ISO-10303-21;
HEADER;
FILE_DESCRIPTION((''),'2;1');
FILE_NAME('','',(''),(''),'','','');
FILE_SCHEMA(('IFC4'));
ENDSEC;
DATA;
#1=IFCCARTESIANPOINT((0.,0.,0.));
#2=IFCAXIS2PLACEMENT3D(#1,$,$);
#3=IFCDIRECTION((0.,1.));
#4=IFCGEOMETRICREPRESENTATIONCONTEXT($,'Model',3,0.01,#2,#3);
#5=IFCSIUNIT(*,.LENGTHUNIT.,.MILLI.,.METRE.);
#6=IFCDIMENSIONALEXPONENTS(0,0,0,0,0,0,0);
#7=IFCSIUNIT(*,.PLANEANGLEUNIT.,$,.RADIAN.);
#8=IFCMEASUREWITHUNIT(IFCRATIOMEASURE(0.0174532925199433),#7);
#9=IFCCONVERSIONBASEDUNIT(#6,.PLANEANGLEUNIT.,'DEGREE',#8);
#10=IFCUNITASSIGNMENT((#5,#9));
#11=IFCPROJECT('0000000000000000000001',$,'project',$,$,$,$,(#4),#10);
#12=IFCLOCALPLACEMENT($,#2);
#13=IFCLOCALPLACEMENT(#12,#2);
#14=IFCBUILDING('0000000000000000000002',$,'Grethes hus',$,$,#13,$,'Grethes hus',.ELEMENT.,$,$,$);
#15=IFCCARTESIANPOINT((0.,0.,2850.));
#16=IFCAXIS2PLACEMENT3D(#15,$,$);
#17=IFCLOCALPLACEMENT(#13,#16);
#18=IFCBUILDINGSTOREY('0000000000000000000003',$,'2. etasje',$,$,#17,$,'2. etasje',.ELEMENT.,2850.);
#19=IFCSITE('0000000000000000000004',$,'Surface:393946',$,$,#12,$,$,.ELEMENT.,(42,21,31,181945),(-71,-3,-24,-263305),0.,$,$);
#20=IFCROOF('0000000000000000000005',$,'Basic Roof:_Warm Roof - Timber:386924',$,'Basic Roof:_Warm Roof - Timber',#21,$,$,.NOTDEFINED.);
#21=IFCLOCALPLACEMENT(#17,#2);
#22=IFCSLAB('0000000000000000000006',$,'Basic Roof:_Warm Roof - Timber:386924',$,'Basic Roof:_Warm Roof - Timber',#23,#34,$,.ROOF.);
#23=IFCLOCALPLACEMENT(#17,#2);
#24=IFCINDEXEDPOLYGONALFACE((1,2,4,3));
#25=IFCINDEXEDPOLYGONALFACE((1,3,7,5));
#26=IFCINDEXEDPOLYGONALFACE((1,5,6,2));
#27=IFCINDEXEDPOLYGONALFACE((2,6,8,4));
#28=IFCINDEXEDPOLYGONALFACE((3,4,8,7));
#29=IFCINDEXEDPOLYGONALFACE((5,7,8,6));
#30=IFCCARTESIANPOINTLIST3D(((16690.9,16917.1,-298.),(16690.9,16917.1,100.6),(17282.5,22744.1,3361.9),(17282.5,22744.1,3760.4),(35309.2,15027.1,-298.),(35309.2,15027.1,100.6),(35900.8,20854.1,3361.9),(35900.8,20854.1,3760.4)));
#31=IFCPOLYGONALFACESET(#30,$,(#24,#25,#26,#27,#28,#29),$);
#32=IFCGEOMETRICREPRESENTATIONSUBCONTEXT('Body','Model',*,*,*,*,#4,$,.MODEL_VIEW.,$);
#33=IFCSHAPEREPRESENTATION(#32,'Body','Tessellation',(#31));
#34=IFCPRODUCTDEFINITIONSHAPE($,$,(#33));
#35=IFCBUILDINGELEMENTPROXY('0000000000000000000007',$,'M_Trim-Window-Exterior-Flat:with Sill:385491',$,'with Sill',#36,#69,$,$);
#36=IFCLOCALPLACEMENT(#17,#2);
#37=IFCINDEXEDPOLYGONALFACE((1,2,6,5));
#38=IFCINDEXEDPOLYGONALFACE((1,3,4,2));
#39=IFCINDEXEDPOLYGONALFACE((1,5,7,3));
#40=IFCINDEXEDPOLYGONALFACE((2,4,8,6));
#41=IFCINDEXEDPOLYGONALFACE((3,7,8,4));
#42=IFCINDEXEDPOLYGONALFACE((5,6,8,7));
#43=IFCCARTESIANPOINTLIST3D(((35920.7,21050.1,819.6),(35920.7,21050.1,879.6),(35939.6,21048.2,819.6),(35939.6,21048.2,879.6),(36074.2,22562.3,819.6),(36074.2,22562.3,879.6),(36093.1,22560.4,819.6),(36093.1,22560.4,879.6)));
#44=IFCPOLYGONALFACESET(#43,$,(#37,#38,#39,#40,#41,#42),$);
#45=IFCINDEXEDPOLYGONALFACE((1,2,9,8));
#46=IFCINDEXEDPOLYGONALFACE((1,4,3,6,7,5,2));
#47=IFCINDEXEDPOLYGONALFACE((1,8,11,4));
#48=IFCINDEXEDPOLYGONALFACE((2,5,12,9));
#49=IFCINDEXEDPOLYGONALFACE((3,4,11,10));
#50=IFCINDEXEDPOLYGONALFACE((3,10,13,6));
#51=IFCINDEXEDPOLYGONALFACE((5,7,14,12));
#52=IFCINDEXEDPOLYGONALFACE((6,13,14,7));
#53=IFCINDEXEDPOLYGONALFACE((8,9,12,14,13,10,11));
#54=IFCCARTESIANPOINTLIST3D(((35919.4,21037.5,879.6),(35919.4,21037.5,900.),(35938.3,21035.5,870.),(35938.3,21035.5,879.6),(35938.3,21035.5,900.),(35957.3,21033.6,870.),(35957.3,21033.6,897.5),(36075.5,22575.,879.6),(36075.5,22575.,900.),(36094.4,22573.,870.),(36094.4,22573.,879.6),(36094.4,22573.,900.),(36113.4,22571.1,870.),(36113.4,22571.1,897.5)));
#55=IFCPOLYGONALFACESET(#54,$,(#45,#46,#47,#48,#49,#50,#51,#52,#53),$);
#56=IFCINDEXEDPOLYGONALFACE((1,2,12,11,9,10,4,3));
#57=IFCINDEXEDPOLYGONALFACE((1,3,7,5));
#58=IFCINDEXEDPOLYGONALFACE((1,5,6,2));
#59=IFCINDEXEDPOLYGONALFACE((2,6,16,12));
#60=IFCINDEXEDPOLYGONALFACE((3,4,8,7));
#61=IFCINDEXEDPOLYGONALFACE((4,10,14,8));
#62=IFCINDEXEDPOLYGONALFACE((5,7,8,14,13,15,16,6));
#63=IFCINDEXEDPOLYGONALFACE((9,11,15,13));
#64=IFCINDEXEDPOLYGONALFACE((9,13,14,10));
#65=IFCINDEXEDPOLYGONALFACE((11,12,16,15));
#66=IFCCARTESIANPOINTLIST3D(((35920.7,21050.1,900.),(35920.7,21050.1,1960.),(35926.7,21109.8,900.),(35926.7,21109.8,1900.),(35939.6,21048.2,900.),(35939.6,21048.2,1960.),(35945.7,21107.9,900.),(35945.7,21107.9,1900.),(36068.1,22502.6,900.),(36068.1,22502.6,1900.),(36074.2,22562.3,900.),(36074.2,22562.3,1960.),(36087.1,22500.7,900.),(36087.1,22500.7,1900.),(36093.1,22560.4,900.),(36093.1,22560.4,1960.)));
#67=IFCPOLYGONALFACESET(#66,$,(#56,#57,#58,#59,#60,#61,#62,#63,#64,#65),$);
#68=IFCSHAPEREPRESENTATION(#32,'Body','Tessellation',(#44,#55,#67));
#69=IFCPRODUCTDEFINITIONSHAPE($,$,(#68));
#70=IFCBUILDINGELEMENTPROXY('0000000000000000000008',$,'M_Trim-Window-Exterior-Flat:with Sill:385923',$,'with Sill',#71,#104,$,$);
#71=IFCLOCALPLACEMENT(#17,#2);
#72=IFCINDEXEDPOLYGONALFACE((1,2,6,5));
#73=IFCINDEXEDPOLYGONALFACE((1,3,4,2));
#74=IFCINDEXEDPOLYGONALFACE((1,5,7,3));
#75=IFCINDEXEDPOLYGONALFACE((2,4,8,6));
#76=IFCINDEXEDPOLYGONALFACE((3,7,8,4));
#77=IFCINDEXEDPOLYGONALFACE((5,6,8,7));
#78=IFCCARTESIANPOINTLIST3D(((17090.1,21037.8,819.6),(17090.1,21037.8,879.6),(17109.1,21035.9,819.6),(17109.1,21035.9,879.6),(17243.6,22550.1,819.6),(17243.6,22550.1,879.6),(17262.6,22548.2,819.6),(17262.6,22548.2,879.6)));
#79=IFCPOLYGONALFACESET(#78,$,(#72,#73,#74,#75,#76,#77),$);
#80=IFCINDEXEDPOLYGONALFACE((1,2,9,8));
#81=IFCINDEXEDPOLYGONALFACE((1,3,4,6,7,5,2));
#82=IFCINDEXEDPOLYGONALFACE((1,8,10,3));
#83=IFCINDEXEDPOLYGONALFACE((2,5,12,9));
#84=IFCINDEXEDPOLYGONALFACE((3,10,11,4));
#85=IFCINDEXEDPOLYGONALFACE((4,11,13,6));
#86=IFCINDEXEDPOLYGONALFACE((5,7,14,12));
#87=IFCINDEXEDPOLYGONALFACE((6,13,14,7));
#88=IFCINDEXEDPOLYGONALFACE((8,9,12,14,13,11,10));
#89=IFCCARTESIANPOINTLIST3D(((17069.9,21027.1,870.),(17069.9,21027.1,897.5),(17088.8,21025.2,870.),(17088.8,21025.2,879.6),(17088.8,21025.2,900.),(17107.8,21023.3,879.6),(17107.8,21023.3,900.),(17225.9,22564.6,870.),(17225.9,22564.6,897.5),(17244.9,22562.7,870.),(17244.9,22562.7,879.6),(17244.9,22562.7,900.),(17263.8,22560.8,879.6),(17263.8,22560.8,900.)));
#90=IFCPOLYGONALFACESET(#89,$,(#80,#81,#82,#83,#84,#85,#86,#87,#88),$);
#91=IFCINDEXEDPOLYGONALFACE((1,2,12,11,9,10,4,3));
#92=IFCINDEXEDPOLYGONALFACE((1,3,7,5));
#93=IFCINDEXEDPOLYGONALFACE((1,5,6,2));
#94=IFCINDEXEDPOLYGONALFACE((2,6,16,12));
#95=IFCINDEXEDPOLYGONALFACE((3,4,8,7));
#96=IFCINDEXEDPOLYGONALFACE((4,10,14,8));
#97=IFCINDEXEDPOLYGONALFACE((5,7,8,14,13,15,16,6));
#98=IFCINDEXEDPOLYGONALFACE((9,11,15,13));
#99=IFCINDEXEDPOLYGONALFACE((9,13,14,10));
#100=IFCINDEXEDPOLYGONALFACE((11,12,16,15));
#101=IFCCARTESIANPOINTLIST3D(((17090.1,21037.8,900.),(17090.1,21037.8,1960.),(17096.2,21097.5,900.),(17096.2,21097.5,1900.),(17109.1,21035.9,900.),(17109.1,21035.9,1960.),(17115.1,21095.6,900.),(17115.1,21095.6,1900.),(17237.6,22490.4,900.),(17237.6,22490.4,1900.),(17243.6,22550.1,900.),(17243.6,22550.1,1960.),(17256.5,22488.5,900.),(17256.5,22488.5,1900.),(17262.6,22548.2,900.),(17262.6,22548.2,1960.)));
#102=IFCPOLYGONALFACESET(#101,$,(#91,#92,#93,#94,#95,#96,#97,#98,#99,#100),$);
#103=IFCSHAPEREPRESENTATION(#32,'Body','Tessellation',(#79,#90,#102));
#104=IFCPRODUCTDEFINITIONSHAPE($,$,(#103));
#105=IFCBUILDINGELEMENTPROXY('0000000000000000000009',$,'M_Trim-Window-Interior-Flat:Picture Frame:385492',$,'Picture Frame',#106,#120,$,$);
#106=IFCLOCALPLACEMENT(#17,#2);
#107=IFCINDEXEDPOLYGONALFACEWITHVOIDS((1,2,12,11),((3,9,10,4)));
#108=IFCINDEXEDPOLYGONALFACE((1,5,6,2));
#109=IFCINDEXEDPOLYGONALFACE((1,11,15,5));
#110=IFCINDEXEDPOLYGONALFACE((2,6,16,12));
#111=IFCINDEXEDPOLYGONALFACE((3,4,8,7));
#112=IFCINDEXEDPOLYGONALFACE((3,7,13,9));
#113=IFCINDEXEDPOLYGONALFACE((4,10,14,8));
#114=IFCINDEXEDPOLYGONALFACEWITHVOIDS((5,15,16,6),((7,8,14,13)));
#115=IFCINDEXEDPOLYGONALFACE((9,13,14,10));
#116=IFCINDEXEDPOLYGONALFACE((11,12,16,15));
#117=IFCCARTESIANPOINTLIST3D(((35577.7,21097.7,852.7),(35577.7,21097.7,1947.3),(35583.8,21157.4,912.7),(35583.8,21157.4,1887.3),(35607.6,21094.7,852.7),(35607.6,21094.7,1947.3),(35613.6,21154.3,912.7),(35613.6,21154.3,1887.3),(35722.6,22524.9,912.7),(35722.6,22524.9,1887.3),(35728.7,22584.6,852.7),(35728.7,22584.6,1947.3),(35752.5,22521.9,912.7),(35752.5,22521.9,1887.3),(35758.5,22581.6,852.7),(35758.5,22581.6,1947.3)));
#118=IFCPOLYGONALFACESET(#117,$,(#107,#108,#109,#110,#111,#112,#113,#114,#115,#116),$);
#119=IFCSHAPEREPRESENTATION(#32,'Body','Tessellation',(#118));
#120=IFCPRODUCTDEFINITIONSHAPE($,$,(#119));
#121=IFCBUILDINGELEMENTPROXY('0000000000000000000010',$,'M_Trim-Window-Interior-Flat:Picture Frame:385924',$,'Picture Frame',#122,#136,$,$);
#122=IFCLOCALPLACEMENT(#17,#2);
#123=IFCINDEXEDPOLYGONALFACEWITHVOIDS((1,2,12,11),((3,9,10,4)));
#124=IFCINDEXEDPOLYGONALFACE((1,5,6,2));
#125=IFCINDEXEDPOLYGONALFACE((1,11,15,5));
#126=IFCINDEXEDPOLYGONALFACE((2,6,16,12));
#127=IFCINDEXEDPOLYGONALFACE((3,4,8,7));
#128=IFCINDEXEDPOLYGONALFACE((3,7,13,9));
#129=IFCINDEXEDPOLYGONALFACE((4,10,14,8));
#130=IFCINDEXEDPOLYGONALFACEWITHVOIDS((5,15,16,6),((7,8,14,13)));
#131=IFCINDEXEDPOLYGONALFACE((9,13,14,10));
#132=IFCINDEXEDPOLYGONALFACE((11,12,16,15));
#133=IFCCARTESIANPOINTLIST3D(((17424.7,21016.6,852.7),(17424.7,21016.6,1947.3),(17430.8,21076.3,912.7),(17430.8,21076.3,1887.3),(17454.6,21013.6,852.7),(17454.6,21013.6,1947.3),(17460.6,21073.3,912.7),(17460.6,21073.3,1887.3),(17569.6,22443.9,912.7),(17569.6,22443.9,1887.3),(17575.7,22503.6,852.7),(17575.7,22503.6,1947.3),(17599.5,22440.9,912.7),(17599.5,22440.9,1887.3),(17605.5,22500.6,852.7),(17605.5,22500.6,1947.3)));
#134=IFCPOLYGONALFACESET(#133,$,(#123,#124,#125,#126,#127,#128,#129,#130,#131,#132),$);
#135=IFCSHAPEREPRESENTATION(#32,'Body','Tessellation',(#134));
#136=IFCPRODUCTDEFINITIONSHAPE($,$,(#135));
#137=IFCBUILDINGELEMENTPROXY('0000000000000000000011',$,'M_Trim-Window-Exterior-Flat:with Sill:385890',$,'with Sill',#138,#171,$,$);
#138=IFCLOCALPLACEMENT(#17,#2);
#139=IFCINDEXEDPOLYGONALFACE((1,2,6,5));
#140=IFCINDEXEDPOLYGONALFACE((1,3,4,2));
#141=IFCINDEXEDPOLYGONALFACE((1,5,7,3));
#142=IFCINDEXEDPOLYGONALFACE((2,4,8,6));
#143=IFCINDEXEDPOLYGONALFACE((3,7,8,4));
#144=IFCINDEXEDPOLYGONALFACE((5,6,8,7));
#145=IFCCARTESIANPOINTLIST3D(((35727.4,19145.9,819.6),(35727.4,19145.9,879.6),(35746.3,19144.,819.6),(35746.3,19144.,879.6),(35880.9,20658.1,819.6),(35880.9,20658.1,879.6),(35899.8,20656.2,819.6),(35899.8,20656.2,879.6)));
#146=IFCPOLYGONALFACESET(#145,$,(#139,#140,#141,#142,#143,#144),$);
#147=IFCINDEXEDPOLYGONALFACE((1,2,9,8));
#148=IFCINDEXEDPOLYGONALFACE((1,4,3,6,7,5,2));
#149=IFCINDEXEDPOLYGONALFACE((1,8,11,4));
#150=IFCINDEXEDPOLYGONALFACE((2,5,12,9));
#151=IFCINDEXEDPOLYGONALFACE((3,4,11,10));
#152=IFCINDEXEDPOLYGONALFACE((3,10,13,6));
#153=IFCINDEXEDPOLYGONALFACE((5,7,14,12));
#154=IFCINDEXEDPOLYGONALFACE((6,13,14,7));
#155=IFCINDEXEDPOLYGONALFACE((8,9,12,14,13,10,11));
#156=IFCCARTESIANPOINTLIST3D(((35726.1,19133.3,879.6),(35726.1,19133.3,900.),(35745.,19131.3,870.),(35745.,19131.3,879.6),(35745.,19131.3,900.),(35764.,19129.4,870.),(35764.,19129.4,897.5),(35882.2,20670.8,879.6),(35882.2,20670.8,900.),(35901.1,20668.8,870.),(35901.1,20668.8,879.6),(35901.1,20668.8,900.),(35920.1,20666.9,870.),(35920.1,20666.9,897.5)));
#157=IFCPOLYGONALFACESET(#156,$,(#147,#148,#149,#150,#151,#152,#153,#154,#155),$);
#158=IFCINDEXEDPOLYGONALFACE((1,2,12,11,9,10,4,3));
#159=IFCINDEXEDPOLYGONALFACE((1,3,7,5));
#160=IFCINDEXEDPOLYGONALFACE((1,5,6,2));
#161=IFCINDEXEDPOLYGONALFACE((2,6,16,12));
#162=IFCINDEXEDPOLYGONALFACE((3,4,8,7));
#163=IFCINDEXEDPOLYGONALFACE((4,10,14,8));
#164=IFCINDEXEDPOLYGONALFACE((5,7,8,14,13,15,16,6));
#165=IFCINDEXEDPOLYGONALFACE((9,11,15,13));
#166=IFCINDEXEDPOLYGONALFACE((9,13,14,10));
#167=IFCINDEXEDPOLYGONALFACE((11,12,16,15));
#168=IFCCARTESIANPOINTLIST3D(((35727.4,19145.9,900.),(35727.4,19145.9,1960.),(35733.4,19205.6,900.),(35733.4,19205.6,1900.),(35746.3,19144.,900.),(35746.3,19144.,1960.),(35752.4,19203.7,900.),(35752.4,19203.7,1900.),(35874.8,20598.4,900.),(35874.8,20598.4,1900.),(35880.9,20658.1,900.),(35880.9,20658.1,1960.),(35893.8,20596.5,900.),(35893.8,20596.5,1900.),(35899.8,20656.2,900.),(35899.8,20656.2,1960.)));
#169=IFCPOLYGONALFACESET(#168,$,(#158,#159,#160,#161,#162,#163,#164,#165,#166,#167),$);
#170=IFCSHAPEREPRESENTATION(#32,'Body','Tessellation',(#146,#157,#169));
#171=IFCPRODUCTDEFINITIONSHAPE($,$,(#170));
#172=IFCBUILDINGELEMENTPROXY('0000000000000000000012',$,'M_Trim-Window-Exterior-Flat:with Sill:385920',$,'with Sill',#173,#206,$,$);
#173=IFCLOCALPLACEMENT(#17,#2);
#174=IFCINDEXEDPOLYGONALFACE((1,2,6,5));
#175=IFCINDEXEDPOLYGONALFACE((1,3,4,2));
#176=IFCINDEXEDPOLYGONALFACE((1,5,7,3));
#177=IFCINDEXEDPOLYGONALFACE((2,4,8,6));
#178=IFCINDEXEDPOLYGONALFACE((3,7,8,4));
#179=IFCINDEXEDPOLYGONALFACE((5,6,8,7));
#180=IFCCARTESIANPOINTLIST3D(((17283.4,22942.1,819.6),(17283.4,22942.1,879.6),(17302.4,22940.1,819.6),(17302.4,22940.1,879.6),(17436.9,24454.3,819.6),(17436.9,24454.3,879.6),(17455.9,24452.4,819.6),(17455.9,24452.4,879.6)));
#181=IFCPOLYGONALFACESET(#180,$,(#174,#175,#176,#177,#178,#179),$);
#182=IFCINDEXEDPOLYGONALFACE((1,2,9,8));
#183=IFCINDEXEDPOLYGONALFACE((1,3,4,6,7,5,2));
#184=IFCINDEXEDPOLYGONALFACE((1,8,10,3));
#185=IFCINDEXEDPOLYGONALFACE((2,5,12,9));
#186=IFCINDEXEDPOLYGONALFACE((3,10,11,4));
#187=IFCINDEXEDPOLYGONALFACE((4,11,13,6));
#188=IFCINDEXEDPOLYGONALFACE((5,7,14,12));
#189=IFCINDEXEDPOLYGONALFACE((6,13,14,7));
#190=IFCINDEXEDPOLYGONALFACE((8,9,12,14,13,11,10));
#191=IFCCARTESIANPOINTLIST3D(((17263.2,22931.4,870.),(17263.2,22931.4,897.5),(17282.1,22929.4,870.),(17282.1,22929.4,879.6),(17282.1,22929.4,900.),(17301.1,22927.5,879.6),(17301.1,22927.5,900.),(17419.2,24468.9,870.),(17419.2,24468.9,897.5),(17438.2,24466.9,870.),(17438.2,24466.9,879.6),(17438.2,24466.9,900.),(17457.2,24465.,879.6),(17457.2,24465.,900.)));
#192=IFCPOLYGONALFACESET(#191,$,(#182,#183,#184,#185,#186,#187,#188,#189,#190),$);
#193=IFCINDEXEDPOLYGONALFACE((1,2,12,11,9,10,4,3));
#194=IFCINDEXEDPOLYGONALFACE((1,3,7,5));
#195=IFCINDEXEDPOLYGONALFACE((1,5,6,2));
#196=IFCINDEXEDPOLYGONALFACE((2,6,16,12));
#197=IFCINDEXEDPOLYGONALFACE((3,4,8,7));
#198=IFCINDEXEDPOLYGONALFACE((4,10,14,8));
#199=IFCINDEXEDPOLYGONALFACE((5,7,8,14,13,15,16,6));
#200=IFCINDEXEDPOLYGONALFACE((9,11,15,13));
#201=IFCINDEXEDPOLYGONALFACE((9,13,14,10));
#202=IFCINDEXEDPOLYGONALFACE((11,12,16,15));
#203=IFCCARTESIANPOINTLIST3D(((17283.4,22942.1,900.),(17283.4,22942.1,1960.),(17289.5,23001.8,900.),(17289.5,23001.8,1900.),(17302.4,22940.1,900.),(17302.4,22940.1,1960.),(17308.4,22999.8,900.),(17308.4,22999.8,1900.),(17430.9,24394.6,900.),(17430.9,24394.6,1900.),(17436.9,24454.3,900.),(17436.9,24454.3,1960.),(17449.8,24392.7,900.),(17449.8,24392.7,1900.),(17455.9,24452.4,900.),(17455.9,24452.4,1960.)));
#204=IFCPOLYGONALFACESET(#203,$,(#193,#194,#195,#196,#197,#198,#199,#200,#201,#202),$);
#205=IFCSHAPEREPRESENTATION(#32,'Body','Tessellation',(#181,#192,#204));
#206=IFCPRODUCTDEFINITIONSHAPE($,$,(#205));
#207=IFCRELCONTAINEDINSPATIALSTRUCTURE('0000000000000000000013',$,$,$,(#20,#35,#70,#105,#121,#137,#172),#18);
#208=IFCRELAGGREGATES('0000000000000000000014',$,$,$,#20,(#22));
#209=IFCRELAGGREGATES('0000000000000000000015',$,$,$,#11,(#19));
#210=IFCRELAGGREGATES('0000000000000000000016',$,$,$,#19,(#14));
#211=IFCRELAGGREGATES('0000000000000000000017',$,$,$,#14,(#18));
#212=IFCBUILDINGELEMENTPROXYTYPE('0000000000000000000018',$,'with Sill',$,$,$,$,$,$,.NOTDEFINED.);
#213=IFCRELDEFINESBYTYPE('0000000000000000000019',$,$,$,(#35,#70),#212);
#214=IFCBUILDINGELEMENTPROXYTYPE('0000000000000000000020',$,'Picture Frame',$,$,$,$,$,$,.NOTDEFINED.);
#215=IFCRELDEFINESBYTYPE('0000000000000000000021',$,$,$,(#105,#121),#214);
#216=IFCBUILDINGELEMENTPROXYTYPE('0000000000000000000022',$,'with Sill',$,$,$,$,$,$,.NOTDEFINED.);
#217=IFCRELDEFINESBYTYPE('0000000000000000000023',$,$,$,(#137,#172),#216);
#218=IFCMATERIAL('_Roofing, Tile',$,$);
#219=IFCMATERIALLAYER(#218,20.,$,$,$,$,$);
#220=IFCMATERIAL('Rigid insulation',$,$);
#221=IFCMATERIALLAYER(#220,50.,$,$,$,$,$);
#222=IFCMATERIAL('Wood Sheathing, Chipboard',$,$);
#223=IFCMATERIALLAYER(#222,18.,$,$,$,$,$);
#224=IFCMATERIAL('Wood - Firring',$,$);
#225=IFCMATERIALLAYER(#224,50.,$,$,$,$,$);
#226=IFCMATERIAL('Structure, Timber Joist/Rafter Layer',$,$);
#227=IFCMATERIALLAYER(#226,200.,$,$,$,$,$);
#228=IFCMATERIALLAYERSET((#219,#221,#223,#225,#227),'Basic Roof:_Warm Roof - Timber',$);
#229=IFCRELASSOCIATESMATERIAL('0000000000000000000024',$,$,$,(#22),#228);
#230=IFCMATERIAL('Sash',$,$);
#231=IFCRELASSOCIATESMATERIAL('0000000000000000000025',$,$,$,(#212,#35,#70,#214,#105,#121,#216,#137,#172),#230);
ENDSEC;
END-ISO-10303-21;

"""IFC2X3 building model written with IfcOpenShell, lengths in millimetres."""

from ifc_helpers import new_model, entity, si_unit, converted_unit, direction, frame, frame_2d, origin, place, context, subcontext, project, spatial, polyline, rectangle, outline, extrude, source, transform, mapped, material, layer, layer_set, type_object, type_shapes, element, aggregate, save


model = new_model("IFC2X3")

# Units and contexts
model_context = context("Model", 3, precision=0.01, world=origin(), true_north=direction((0.0, 1.0)))
body_context = subcontext(model_context, "Body", "Model", "MODEL_VIEW")
ifc_project = project(units=[si_unit("LENGTHUNIT", "METRE", prefix="MILLI"), converted_unit("PLANEANGLEUNIT", "DEGREE", entity("IfcRatioMeasure", 0.0174532925199433), si_unit("PLANEANGLEUNIT", "RADIAN"), dimensions=[0, 0, 0, 0, 0, 0, 0])], contexts=[model_context])

# Site, building, storey
site_placement = place(None, origin())
site = spatial("IfcSite", under=ifc_project, at=site_placement, Name="Surface:393946", CompositionType="ELEMENT", RefLatitude=(42, 21, 31, 181945), RefLongitude=(-71, -3, -24, -263305), RefElevation=0.0)
building_placement = place(site_placement, origin())
building = spatial("IfcBuilding", under=site, at=building_placement, Name="Grethes hus", LongName="Grethes hus", CompositionType="ELEMENT")
storey_placement = place(building_placement, frame((0.0, 0.0, 2850.0)))
storey = spatial("IfcBuildingStorey", under=building, at=storey_placement, Name="2. etasje", LongName="2. etasje", CompositionType="ELEMENT", Elevation=2850.0)

# Shared definitions
ifc_material_1 = material(Name="Wood Sheathing, Chipboard")
ifc_material_2 = material(Name="Structure, Timber Joist/Rafter Layer")

# Roof, slab
roof_placement = place(storey_placement, frame((16690.9, 15027.1, -298.0)))
roof = element("IfcRoof", 1, at=roof_placement, inside=storey, Name="Basic Roof:_Warm Roof - Timber:386924", ObjectType="Basic Roof:_Warm Roof - Timber", ShapeType="NOTDEFINED")
ifc_material_3 = material(Name="_Roofing, Tile")
ifc_layer_1 = layer(ifc_material_3, 20.0)
ifc_material_4 = material(Name="Rigid insulation")
ifc_layer_2 = layer(ifc_material_4, 50.0)
ifc_layer_3 = layer(ifc_material_1, 18.0)
ifc_material_5 = material(Name="Wood - Firring")
ifc_layer_4 = layer(ifc_material_5, 50.0)
ifc_layer_5 = layer(ifc_material_2, 200.0)
ifc_layer_set_1 = layer_set([ifc_layer_1, ifc_layer_2, ifc_layer_3, ifc_layer_4, ifc_layer_5], Name="Basic Roof:_Warm Roof - Timber")
slab_1_placement = place(roof_placement, origin())
slab_1 = element("IfcSlab", 2, at=slab_1_placement, material=ifc_layer_set_1, Name="Basic Roof:_Warm Roof - Timber:386924", ObjectType="Basic Roof:_Warm Roof - Timber", PredefinedType="ROOF", context=body_context, shape_type="SweptSolid", body=[
    extrude(rectangle(XDim=6906.4, YDim=18714.0, at=frame_2d((0.0, 0.0), x_axis=(0.085772, 0.996315))), frame((9604.9, 3858.5, 1829.9), z_axis=(-0.05352, -0.52721, 0.848048), x_axis=(0.998567, -0.028257, 0.045452)), (0.045452, 0.527966, 0.848048), 398.6),
])
aggregate(roof, [slab_1])

# Building element proxies
ifc_material_6 = material(Name="Sash")
building_element_proxy_type_1 = type_object("IfcBuildingElementProxyType", Name="with Sill", PredefinedType="NOTDEFINED", material=ifc_material_6)
shared_shape_1 = source(origin(), body_context, "Body", "SweptSolid", [
    extrude(rectangle(XDim=1520.0, YDim=60.0, at=frame_2d((0.0, 0.0), x_axis=(1.0, 0.0))), frame((0.0, -1050.4, 0.0), z_axis=(0.0, 0.0, 1.0), x_axis=(-1.0, 0.0, 0.0)), (0.0, 0.0, 1.0), 19.1),
    extrude(outline(polyline([(-19.0, -15.2), (0.0, -15.2), (0.0, -5.7), (19.0, -5.7), (19.0, 14.8), (0.0, 14.8), (-19.0, 12.3), (-19.0, -15.2)])), frame((-772.7, -1014.8, 19.0), z_axis=(1.0, 0.0, 0.0), x_axis=(0.0, 0.0, -1.0)), (0.0, 0.0, 1.0), 1545.4),
    extrude(outline(polyline([(-545.0, -760.0), (515.0, -760.0), (515.0, -700.0), (-485.0, -700.0), (-485.0, 700.0), (515.0, 700.0), (515.0, 760.0), (-545.0, 760.0), (-545.0, -760.0)])), frame((0.0, -485.0, 0.0), z_axis=(0.0, 0.0, 1.0), x_axis=(0.0, -1.0, 0.0)), (0.0, 0.0, 1.0), 19.1),
])
type_shapes(building_element_proxy_type_1, [shared_shape_1])
for number, where, z_axis, x_axis, name in (
    (3, (35997.4, 21806.2, 1900.0), (0.994887, -0.100996, 0.0), (0.100996, 0.994887, 0.0), "M_Trim-Window-Exterior-Flat:with Sill:385491"),
    (4, (17185.8, 21792.0, 1900.0), (-0.994887, 0.100996, 0.0), (-0.100996, -0.994887, 0.0), "M_Trim-Window-Exterior-Flat:with Sill:385923"),
):
    element("IfcBuildingElementProxy", number, at=place(storey_placement, frame(where, z_axis=z_axis, x_axis=x_axis)), inside=storey, type_object=building_element_proxy_type_1, material=ifc_material_6, Name=name, ObjectType="with Sill", context=body_context, shape_type="MappedRepresentation", body=[
        mapped(shared_shape_1, transform((0.0, 0.0, 0.0), scale=1.0)),
    ])
building_element_proxy_type_2 = type_object("IfcBuildingElementProxyType", Name="Picture Frame", PredefinedType="NOTDEFINED", material=ifc_material_6)
shared_shape_2 = source(origin(), body_context, "Body", "SweptSolid", [
    extrude(outline(polyline([(-747.3, -547.3), (747.3, -547.3), (747.3, 547.3), (-747.3, 547.3), (-747.3, -547.3)]), holes=[polyline([(-687.3, -487.3), (-687.3, 487.3), (687.3, 487.3), (687.3, -487.3), (-687.3, -487.3)])]), frame((0.0, -500.0, 0.0), z_axis=(0.0, 0.0, 1.0), x_axis=(-1.0, 0.0, 0.0)), (0.0, 0.0, 1.0), 30.0),
])
type_shapes(building_element_proxy_type_2, [shared_shape_2])
for number, where, z_axis, x_axis, name in (
    (5, (35683.0, 21838.1, 1900.0), (-0.994887, 0.100996, 0.0), (-0.100996, -0.994887, 0.0), "M_Trim-Window-Interior-Flat:Picture Frame:385492"),
    (6, (17500.2, 21760.1, 1900.0), (0.994887, -0.100996, 0.0), (0.100996, 0.994887, 0.0), "M_Trim-Window-Interior-Flat:Picture Frame:385924"),
):
    element("IfcBuildingElementProxy", number, at=place(storey_placement, frame(where, z_axis=z_axis, x_axis=x_axis)), inside=storey, type_object=building_element_proxy_type_2, material=ifc_material_6, Name=name, ObjectType="Picture Frame", context=body_context, shape_type="MappedRepresentation", body=[
        mapped(shared_shape_2, transform((0.0, 0.0, 0.0), scale=1.0)),
    ])
building_element_proxy_type_3 = type_object("IfcBuildingElementProxyType", Name="with Sill", PredefinedType="NOTDEFINED", material=ifc_material_6)
shared_shape_3 = source(origin(), body_context, "Body", "SweptSolid", [
    extrude(rectangle(XDim=60.0, YDim=1520.0, at=frame_2d((0.0, 0.0), x_axis=(1.0, 0.0))), frame((0.0, 1050.4, 0.0), z_axis=(0.0, 0.0, 1.0), x_axis=(0.0, 1.0, 0.0)), (0.0, 0.0, 1.0), 19.1),
    extrude(outline(polyline([(-15.2, -19.0), (12.3, -19.0), (14.8, 0.0), (14.8, 19.0), (-5.7, 19.0), (-5.7, 0.0), (-15.2, 0.0), (-15.2, -19.0)])), frame((-772.7, 1014.8, 19.0), z_axis=(1.0, 0.0, 0.0), x_axis=(0.0, -1.0, 0.0)), (0.0, 0.0, 1.0), 1545.4),
    extrude(outline(polyline([(-760.0, -545.0), (760.0, -545.0), (760.0, 515.0), (700.0, 515.0), (700.0, -485.0), (-700.0, -485.0), (-700.0, 515.0), (-760.0, 515.0), (-760.0, -545.0)])), frame((0.0, 485.0, 0.0)), (0.0, 0.0, 1.0), 19.1),
])
type_shapes(building_element_proxy_type_3, [shared_shape_3])
for number, where, z_axis, x_axis, name in (
    (7, (35804.1, 19902.0, 1900.0), (0.994887, -0.100996, 0.0), (-0.100996, -0.994887, 0.0), "M_Trim-Window-Exterior-Flat:with Sill:385890"),
    (8, (17379.1, 23696.3, 1900.0), (-0.994887, 0.100996, 0.0), (0.100996, 0.994887, 0.0), "M_Trim-Window-Exterior-Flat:with Sill:385920"),
):
    element("IfcBuildingElementProxy", number, at=place(storey_placement, frame(where, z_axis=z_axis, x_axis=x_axis)), inside=storey, type_object=building_element_proxy_type_3, material=ifc_material_6, Name=name, ObjectType="with Sill", context=body_context, shape_type="MappedRepresentation", body=[
        mapped(shared_shape_3, transform((0.0, 0.0, 0.0), scale=1.0)),
    ])

save(model, "model.ifc")
